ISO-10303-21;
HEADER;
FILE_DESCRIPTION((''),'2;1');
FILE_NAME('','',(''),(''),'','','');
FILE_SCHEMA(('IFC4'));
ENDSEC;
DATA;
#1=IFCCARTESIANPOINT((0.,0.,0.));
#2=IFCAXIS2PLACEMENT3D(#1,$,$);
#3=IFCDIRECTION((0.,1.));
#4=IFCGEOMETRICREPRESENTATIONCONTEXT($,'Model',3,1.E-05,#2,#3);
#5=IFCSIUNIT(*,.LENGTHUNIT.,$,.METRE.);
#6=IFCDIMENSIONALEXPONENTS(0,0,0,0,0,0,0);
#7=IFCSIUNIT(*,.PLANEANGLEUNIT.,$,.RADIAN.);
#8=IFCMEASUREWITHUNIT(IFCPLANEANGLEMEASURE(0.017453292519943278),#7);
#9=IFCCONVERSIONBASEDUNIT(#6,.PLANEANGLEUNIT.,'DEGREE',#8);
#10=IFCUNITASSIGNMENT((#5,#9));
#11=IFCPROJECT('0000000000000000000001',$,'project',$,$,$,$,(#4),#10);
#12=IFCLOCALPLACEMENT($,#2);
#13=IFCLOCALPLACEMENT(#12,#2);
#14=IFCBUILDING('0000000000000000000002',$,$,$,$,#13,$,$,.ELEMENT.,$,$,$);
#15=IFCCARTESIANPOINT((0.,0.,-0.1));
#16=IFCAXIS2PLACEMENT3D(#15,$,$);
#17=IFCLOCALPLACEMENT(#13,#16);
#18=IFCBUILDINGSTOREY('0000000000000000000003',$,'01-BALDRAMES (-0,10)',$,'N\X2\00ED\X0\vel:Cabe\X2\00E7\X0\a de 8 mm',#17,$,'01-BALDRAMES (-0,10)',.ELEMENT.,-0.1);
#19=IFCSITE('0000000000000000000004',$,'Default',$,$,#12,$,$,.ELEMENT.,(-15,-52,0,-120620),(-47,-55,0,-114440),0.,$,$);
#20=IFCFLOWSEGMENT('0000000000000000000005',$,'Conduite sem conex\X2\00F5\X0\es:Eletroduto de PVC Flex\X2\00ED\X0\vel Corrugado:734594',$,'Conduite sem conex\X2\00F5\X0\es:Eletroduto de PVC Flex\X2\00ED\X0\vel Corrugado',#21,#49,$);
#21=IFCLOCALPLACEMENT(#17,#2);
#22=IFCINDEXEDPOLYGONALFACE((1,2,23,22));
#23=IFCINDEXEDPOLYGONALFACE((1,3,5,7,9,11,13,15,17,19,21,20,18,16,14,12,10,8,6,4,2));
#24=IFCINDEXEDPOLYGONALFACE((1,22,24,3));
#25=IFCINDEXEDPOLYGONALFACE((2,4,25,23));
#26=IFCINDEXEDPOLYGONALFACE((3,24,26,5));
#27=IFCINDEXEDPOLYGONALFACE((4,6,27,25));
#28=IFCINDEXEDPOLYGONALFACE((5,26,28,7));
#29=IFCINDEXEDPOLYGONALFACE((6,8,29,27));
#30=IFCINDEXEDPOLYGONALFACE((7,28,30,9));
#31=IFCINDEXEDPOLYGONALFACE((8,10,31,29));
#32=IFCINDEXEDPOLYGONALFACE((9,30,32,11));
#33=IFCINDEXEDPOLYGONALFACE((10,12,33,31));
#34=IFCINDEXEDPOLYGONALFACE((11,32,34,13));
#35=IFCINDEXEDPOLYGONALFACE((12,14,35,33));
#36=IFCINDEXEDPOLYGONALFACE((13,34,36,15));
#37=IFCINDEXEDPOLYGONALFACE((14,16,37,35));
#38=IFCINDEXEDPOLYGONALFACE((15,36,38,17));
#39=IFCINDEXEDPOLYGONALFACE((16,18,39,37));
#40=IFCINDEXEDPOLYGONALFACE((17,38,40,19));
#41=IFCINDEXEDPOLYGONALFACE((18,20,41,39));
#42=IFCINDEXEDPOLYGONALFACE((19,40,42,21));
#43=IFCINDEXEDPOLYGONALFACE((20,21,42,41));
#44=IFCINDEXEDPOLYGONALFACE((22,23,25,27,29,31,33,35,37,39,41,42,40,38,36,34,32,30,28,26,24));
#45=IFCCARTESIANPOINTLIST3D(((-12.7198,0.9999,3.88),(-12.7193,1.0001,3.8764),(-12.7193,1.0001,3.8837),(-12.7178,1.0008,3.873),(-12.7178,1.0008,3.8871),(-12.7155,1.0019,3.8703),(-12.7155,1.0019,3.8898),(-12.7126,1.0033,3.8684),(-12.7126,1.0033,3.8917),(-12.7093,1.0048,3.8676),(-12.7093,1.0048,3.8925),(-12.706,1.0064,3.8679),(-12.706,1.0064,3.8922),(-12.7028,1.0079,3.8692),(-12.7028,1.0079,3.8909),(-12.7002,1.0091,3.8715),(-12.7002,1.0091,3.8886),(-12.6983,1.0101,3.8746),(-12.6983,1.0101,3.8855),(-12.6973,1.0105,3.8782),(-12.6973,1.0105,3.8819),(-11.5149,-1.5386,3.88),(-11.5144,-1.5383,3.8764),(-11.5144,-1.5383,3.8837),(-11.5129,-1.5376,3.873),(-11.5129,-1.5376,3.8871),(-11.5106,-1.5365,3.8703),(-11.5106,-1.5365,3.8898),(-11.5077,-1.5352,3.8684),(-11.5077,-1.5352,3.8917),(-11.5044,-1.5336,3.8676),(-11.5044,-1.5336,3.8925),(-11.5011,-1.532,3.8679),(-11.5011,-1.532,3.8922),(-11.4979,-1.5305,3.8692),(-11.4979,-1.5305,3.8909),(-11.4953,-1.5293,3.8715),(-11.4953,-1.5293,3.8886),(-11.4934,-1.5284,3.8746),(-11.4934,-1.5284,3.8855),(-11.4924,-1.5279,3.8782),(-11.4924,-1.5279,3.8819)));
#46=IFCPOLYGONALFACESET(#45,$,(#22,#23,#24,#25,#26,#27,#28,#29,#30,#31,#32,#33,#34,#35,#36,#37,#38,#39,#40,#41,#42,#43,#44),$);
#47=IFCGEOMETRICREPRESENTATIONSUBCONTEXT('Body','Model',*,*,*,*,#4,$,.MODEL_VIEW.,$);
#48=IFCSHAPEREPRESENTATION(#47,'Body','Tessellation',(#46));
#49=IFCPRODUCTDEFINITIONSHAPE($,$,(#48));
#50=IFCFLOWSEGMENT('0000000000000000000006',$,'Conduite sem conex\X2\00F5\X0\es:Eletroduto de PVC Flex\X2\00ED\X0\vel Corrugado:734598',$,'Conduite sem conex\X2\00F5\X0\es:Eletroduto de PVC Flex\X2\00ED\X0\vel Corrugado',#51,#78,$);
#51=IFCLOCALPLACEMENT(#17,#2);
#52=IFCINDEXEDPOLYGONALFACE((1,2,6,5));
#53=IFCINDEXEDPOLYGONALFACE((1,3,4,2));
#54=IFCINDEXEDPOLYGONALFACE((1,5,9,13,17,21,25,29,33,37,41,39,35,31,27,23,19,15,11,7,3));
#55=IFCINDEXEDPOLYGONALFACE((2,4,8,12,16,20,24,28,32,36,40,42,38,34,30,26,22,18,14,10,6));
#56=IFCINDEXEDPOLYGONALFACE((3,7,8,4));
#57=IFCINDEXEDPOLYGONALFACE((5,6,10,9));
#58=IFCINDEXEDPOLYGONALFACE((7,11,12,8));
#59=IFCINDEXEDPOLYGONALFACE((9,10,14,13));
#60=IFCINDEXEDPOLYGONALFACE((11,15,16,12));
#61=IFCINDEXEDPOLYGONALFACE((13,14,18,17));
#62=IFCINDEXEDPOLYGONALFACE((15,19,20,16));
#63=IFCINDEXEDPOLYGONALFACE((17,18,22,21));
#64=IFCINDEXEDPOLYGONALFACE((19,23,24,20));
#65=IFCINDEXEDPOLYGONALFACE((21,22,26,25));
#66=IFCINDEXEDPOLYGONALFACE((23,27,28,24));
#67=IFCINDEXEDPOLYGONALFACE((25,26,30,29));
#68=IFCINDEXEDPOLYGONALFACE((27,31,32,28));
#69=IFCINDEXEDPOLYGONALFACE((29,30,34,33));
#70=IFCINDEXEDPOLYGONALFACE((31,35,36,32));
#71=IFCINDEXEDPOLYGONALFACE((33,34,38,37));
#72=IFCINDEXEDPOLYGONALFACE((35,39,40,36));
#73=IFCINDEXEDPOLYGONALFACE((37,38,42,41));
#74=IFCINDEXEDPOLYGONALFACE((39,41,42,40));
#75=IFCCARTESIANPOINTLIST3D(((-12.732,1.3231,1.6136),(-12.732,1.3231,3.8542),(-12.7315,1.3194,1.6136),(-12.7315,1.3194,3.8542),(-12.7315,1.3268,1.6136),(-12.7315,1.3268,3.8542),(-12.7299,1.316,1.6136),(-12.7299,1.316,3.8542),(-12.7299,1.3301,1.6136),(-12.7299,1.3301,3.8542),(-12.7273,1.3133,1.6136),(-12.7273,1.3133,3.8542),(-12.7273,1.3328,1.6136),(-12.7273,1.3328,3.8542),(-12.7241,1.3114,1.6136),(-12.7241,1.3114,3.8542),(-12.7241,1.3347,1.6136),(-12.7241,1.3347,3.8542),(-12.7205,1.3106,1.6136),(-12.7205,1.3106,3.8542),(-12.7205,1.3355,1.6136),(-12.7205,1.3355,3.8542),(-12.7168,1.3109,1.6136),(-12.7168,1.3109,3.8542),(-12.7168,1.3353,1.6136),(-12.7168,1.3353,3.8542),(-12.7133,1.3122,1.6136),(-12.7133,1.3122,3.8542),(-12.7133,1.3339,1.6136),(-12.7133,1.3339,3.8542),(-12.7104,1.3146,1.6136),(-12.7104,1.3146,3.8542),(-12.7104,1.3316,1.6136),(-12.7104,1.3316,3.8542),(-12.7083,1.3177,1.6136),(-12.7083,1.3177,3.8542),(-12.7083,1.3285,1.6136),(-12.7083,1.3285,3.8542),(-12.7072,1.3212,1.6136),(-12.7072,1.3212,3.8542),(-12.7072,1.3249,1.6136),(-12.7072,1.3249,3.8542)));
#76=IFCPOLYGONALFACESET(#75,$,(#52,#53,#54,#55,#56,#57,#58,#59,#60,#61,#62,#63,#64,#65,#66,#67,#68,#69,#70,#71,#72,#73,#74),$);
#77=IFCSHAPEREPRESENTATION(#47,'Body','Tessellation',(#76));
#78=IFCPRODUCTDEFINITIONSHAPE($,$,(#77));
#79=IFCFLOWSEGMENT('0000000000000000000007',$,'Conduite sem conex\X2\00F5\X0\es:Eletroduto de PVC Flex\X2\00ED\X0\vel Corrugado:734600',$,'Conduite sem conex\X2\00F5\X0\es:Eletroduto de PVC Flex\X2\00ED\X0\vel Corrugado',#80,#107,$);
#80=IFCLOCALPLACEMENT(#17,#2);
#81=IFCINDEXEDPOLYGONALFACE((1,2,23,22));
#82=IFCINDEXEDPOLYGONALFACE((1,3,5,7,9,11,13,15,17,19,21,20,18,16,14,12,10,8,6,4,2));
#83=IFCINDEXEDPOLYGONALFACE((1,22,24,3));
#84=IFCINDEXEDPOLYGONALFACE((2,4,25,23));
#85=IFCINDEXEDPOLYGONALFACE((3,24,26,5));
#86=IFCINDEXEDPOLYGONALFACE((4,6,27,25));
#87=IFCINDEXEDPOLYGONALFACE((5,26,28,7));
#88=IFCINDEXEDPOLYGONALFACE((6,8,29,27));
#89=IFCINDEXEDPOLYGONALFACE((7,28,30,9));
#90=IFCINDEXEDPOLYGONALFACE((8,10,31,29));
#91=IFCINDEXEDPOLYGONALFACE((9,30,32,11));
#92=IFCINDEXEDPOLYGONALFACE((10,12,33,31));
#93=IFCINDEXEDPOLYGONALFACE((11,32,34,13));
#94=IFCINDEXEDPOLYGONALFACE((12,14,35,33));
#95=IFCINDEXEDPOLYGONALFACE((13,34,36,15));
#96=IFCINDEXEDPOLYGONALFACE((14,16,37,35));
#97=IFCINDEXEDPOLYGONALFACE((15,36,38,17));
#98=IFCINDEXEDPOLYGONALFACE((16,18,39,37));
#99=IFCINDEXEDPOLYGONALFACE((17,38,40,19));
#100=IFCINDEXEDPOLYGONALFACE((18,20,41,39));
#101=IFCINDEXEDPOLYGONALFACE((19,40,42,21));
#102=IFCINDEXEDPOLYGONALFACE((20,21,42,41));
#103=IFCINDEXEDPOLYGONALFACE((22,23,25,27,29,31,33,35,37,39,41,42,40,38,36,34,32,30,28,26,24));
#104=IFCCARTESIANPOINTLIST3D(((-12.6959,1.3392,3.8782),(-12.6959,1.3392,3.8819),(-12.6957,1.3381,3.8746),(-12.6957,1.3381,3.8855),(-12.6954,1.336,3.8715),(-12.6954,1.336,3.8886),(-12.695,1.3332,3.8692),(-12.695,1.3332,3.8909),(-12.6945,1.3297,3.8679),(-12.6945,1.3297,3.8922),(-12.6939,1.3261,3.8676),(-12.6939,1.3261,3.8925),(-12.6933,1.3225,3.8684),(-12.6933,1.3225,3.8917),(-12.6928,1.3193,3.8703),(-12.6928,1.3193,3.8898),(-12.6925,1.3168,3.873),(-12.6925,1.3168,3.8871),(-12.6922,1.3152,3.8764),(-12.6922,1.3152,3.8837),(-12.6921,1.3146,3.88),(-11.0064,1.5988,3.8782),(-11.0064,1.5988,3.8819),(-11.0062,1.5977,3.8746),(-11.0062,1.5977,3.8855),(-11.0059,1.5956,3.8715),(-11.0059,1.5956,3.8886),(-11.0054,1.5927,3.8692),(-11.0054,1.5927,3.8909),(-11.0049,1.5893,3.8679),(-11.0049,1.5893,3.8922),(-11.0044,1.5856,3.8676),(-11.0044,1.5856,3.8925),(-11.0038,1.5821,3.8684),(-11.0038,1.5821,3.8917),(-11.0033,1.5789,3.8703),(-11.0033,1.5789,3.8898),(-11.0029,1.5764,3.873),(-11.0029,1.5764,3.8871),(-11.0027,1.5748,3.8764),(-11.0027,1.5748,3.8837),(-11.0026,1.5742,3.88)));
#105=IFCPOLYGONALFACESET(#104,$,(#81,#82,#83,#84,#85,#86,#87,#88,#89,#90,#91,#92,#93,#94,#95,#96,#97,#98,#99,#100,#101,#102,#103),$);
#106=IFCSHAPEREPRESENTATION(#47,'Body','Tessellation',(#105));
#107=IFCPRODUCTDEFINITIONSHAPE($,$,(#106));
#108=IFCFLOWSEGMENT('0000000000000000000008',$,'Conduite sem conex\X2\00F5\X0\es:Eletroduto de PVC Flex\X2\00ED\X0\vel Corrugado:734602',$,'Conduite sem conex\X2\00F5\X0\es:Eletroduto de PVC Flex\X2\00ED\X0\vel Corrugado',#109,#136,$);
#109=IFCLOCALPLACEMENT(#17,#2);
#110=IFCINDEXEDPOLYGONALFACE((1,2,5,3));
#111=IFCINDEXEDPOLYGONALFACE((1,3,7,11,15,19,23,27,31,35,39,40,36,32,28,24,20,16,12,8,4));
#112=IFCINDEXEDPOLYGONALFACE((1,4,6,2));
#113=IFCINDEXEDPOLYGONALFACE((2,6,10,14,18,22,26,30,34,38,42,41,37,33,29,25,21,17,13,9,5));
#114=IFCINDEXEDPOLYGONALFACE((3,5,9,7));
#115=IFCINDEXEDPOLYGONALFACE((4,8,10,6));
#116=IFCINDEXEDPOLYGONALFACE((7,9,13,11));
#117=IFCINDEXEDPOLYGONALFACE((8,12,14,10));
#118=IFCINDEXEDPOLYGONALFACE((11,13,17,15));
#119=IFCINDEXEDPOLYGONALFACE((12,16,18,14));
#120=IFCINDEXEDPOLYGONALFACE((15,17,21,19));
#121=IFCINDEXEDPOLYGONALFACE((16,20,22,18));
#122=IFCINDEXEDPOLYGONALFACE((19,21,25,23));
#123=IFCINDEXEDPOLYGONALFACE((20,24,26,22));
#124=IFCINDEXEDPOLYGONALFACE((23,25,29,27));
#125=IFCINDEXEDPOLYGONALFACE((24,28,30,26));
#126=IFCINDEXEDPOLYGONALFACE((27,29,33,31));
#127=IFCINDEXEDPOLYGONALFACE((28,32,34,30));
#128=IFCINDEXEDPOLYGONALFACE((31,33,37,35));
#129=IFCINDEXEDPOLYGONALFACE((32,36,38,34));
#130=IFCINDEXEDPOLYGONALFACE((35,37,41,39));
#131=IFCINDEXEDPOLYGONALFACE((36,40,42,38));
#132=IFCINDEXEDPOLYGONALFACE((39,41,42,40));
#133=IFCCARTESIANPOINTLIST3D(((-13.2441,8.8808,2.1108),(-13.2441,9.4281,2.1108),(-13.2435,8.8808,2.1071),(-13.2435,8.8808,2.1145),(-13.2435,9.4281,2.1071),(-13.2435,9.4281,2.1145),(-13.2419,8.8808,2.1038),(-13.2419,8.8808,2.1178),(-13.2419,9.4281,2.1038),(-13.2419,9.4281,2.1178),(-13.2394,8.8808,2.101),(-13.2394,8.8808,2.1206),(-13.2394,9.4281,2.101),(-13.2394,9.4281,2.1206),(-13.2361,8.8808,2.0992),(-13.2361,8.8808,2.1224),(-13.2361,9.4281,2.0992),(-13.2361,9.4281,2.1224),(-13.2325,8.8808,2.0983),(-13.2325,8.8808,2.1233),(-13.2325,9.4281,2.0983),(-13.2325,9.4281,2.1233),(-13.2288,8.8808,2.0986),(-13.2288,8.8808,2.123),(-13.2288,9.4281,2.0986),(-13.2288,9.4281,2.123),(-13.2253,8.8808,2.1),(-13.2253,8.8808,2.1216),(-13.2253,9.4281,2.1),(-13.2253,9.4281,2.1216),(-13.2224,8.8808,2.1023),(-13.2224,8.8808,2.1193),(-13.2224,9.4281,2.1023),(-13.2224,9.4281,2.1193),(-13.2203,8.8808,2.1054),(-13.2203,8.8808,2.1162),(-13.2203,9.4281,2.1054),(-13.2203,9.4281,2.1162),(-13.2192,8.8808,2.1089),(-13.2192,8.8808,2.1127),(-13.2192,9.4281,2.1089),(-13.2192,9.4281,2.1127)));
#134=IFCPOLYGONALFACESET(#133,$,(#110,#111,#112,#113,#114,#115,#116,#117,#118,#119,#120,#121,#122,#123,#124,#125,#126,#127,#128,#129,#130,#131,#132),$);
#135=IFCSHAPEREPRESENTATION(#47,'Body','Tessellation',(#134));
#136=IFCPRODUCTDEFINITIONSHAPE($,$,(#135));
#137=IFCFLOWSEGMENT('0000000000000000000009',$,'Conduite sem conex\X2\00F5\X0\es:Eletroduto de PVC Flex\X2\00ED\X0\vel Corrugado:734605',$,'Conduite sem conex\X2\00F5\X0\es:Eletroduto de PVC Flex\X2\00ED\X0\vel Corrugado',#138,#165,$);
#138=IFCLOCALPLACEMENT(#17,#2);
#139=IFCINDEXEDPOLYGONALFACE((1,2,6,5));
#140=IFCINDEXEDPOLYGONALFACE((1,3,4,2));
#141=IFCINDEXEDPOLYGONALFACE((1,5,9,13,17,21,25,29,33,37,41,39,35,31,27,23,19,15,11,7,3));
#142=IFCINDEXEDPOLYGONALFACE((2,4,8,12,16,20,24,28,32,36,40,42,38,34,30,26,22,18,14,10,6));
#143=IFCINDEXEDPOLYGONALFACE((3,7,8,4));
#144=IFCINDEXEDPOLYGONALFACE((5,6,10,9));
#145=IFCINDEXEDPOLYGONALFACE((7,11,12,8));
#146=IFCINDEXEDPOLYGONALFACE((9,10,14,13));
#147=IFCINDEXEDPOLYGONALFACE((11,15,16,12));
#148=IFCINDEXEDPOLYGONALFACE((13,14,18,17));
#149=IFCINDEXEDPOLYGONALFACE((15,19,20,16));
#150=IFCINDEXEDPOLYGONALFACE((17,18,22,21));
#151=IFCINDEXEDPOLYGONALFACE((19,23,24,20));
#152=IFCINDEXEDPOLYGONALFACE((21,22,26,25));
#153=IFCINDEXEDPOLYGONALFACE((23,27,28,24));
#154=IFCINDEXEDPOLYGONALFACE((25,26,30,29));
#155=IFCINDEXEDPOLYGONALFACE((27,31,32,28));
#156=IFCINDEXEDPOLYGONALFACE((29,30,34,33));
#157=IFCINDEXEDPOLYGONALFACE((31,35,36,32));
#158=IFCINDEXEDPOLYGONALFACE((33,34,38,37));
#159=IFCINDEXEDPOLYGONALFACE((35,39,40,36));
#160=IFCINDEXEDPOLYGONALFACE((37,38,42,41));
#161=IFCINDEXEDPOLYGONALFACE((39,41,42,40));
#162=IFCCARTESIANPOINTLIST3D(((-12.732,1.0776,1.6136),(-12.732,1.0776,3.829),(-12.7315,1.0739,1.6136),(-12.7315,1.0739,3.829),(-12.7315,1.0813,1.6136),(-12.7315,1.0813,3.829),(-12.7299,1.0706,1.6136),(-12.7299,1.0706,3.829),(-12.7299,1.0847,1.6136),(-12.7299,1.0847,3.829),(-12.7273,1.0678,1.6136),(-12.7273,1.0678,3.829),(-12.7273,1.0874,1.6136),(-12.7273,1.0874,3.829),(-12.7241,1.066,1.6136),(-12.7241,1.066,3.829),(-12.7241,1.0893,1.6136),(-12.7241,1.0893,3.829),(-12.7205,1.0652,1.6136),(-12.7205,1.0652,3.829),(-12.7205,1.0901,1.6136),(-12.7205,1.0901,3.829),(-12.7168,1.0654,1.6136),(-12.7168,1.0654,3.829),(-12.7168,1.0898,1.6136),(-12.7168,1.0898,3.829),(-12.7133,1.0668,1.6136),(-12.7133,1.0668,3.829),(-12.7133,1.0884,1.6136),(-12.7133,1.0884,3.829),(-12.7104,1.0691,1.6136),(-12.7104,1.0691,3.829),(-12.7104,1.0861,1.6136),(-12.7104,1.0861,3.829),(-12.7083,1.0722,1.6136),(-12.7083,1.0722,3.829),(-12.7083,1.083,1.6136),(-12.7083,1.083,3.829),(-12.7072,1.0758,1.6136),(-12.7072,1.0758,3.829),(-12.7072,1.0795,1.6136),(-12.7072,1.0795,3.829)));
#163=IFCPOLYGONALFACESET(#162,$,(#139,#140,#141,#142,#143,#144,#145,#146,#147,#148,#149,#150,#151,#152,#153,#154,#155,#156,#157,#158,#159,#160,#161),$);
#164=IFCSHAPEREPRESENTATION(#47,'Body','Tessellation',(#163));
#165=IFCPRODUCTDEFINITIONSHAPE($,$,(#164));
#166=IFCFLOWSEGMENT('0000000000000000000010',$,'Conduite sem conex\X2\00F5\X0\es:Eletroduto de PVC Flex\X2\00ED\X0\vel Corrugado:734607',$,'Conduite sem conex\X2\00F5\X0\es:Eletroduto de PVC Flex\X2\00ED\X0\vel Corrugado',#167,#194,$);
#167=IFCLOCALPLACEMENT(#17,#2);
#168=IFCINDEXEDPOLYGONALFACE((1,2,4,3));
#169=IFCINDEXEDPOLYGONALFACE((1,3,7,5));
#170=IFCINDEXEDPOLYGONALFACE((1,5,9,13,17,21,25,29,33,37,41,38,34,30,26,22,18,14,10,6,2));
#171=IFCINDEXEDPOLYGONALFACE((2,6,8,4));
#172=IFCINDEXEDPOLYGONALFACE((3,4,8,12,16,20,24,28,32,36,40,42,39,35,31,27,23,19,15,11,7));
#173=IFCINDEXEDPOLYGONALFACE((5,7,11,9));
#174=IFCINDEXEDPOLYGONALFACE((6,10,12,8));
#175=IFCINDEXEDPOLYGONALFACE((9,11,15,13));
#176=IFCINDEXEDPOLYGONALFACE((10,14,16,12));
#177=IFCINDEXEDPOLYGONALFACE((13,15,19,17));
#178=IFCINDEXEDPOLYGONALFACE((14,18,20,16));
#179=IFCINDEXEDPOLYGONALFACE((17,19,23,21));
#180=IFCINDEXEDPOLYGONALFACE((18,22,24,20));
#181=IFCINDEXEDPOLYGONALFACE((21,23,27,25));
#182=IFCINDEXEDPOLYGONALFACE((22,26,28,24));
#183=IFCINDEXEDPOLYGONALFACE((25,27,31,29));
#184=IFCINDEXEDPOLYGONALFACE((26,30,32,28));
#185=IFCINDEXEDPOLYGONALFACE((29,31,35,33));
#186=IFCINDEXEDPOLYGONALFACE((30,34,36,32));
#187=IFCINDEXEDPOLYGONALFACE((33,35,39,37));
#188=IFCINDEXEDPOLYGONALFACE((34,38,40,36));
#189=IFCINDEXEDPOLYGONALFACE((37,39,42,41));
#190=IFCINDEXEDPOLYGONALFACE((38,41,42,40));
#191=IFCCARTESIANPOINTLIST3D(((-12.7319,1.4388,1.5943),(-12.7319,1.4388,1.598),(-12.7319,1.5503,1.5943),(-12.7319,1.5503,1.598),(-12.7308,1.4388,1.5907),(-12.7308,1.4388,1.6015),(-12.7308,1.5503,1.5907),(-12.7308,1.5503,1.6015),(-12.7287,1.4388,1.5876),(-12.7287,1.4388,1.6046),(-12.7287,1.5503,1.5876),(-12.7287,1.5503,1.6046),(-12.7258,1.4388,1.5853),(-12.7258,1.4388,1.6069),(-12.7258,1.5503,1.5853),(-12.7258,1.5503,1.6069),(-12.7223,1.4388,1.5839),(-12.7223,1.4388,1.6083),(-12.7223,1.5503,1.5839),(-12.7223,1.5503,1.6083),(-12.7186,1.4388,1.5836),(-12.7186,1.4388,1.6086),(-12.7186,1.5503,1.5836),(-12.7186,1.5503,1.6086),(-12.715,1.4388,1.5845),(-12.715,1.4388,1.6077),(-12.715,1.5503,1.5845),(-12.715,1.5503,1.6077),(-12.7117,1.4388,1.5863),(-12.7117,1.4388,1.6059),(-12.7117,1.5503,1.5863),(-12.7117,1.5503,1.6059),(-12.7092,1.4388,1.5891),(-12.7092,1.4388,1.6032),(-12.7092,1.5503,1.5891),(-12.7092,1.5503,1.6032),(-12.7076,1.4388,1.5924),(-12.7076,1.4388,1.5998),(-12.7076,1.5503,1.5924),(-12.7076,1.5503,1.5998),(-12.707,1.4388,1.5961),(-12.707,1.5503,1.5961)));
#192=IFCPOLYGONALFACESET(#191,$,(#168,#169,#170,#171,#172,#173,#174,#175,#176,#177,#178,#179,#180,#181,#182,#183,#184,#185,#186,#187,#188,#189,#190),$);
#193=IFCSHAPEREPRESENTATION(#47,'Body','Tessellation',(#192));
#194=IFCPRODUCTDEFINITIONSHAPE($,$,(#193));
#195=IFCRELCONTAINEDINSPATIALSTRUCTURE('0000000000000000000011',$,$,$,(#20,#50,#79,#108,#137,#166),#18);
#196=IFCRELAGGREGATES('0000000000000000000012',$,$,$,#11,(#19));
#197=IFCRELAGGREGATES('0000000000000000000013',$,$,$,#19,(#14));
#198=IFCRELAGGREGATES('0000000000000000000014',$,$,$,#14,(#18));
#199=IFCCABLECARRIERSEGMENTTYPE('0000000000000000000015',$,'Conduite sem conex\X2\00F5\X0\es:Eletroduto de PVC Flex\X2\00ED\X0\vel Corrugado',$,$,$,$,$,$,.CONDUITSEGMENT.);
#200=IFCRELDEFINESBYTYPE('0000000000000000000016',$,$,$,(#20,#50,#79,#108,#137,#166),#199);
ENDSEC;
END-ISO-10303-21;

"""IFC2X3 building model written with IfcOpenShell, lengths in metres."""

from ifc_helpers import new_model, entity, si_unit, converted_unit, direction, frame, frame_2d, origin, origin_2d_with_axis, place, context, subcontext, project, spatial, circle, extrude, type_object, element, save


model = new_model("IFC2X3")

# Units and contexts
model_context = context("Model", 3, precision=1e-05, world=origin(), true_north=direction((0.0, 1.0)))
body_context = subcontext(model_context, "Body", "Model", "MODEL_VIEW")
ifc_project = project(units=[si_unit("LENGTHUNIT", "METRE"), converted_unit("PLANEANGLEUNIT", "DEGREE", entity("IfcPlaneAngleMeasure", 0.017453292519943278), si_unit("PLANEANGLEUNIT", "RADIAN"), dimensions=[0, 0, 0, 0, 0, 0, 0])], contexts=[model_context])

# Site, building, storey
site_placement = place(None, origin())
site = spatial("IfcSite", under=ifc_project, at=site_placement, Name="Default", CompositionType="ELEMENT", RefLatitude=(-15, -52, 0, -120620), RefLongitude=(-47, -55, 0, -114440), RefElevation=0.0)
building_placement = place(site_placement, origin())
building = spatial("IfcBuilding", under=site, at=building_placement, CompositionType="ELEMENT")
storey_placement = place(building_placement, frame((0.0, 0.0, -0.1)))
storey = spatial("IfcBuildingStorey", under=building, at=storey_placement, Name="01-BALDRAMES (-0,10)", ObjectType="Nível:Cabeça de 8 mm", LongName="01-BALDRAMES (-0,10)", CompositionType="ELEMENT", Elevation=-0.1)

# Flow segments
cable_carrier_segment_type = type_object("IfcCableCarrierSegmentType", Name="Conduite sem conexões:Eletroduto de PVC Flexível Corrugado", PredefinedType="CONDUITSEGMENT")
flow_segment_1_placement = place(storey_placement, origin())
element("IfcFlowSegment", 1, at=flow_segment_1_placement, inside=storey, type_object=cable_carrier_segment_type, Name="Conduite sem conexões:Eletroduto de PVC Flexível Corrugado:734594", ObjectType="Conduite sem conexões:Eletroduto de PVC Flexível Corrugado", context=body_context, shape_type="SweptSolid", body=[
    extrude(circle(Radius=0.0125, at=origin_2d_with_axis()), frame((-11.5036, -1.5332, 3.88), z_axis=(-0.428806, 0.903397, 0.0), x_axis=(-0.903397, -0.428806, 0.0)), (0.0, 0.0, 1.0), 2.8099),
])
flow_segment_2_placement = place(storey_placement, origin())
element("IfcFlowSegment", 2, at=flow_segment_2_placement, inside=storey, type_object=cable_carrier_segment_type, Name="Conduite sem conexões:Eletroduto de PVC Flexível Corrugado:734598", ObjectType="Conduite sem conexões:Eletroduto de PVC Flexível Corrugado", context=body_context, shape_type="SweptSolid", body=[
    extrude(circle(Radius=0.0125, at=origin_2d_with_axis()), frame((-12.7195, 1.3231, 1.6136), z_axis=(0.0, 0.0, 1.0), x_axis=(-1.0, 0.0, 0.0)), (0.0, 0.0, 1.0), 2.2406),
])
flow_segment_3_placement = place(storey_placement, origin())
element("IfcFlowSegment", 3, at=flow_segment_3_placement, inside=storey, type_object=cable_carrier_segment_type, Name="Conduite sem conexões:Eletroduto de PVC Flexível Corrugado:734600", ObjectType="Conduite sem conexões:Eletroduto de PVC Flexível Corrugado", context=body_context, shape_type="SweptSolid", body=[
    extrude(circle(Radius=0.0125, at=origin_2d_with_axis()), frame((-12.694, 1.327, 3.88), z_axis=(0.988403, 0.151856, 0.0), x_axis=(0.151856, -0.988403, 0.0)), (0.0, 0.0, 1.0), 1.7094),
])
flow_segment_4_placement = place(storey_placement, origin())
element("IfcFlowSegment", 4, at=flow_segment_4_placement, inside=storey, type_object=cable_carrier_segment_type, Name="Conduite sem conexões:Eletroduto de PVC Flexível Corrugado:734602", ObjectType="Conduite sem conexões:Eletroduto de PVC Flexível Corrugado", context=body_context, shape_type="SweptSolid", body=[
    extrude(circle(Radius=0.0125, at=frame_2d((0.0, 0.0), x_axis=(1.0, 0.0))), frame((-13.2316, 8.8808, 2.1108), z_axis=(0.0, 1.0, 0.0), x_axis=(-1.0, 0.0, 0.0)), (0.0, 0.0, 1.0), 0.5473),
])
flow_segment_5_placement = place(storey_placement, origin())
element("IfcFlowSegment", 5, at=flow_segment_5_placement, inside=storey, type_object=cable_carrier_segment_type, Name="Conduite sem conexões:Eletroduto de PVC Flexível Corrugado:734605", ObjectType="Conduite sem conexões:Eletroduto de PVC Flexível Corrugado", context=body_context, shape_type="SweptSolid", body=[
    extrude(circle(Radius=0.0125, at=origin_2d_with_axis()), frame((-12.7195, 1.0776, 1.6136), z_axis=(0.0, 0.0, 1.0), x_axis=(-1.0, 0.0, 0.0)), (0.0, 0.0, 1.0), 2.2154),
])
flow_segment_6_placement = place(storey_placement, origin())
element("IfcFlowSegment", 6, at=flow_segment_6_placement, inside=storey, type_object=cable_carrier_segment_type, Name="Conduite sem conexões:Eletroduto de PVC Flexível Corrugado:734607", ObjectType="Conduite sem conexões:Eletroduto de PVC Flexível Corrugado", context=body_context, shape_type="SweptSolid", body=[
    extrude(circle(Radius=0.0125, at=frame_2d((0.0, 0.0), x_axis=(1.0, 0.0))), frame((-12.7195, 1.4388, 1.5961), z_axis=(0.0, 1.0, 0.0), x_axis=(1.0, 0.0, 0.0)), (0.0, 0.0, 1.0), 0.1116),
])

save(model, "model.ifc")
